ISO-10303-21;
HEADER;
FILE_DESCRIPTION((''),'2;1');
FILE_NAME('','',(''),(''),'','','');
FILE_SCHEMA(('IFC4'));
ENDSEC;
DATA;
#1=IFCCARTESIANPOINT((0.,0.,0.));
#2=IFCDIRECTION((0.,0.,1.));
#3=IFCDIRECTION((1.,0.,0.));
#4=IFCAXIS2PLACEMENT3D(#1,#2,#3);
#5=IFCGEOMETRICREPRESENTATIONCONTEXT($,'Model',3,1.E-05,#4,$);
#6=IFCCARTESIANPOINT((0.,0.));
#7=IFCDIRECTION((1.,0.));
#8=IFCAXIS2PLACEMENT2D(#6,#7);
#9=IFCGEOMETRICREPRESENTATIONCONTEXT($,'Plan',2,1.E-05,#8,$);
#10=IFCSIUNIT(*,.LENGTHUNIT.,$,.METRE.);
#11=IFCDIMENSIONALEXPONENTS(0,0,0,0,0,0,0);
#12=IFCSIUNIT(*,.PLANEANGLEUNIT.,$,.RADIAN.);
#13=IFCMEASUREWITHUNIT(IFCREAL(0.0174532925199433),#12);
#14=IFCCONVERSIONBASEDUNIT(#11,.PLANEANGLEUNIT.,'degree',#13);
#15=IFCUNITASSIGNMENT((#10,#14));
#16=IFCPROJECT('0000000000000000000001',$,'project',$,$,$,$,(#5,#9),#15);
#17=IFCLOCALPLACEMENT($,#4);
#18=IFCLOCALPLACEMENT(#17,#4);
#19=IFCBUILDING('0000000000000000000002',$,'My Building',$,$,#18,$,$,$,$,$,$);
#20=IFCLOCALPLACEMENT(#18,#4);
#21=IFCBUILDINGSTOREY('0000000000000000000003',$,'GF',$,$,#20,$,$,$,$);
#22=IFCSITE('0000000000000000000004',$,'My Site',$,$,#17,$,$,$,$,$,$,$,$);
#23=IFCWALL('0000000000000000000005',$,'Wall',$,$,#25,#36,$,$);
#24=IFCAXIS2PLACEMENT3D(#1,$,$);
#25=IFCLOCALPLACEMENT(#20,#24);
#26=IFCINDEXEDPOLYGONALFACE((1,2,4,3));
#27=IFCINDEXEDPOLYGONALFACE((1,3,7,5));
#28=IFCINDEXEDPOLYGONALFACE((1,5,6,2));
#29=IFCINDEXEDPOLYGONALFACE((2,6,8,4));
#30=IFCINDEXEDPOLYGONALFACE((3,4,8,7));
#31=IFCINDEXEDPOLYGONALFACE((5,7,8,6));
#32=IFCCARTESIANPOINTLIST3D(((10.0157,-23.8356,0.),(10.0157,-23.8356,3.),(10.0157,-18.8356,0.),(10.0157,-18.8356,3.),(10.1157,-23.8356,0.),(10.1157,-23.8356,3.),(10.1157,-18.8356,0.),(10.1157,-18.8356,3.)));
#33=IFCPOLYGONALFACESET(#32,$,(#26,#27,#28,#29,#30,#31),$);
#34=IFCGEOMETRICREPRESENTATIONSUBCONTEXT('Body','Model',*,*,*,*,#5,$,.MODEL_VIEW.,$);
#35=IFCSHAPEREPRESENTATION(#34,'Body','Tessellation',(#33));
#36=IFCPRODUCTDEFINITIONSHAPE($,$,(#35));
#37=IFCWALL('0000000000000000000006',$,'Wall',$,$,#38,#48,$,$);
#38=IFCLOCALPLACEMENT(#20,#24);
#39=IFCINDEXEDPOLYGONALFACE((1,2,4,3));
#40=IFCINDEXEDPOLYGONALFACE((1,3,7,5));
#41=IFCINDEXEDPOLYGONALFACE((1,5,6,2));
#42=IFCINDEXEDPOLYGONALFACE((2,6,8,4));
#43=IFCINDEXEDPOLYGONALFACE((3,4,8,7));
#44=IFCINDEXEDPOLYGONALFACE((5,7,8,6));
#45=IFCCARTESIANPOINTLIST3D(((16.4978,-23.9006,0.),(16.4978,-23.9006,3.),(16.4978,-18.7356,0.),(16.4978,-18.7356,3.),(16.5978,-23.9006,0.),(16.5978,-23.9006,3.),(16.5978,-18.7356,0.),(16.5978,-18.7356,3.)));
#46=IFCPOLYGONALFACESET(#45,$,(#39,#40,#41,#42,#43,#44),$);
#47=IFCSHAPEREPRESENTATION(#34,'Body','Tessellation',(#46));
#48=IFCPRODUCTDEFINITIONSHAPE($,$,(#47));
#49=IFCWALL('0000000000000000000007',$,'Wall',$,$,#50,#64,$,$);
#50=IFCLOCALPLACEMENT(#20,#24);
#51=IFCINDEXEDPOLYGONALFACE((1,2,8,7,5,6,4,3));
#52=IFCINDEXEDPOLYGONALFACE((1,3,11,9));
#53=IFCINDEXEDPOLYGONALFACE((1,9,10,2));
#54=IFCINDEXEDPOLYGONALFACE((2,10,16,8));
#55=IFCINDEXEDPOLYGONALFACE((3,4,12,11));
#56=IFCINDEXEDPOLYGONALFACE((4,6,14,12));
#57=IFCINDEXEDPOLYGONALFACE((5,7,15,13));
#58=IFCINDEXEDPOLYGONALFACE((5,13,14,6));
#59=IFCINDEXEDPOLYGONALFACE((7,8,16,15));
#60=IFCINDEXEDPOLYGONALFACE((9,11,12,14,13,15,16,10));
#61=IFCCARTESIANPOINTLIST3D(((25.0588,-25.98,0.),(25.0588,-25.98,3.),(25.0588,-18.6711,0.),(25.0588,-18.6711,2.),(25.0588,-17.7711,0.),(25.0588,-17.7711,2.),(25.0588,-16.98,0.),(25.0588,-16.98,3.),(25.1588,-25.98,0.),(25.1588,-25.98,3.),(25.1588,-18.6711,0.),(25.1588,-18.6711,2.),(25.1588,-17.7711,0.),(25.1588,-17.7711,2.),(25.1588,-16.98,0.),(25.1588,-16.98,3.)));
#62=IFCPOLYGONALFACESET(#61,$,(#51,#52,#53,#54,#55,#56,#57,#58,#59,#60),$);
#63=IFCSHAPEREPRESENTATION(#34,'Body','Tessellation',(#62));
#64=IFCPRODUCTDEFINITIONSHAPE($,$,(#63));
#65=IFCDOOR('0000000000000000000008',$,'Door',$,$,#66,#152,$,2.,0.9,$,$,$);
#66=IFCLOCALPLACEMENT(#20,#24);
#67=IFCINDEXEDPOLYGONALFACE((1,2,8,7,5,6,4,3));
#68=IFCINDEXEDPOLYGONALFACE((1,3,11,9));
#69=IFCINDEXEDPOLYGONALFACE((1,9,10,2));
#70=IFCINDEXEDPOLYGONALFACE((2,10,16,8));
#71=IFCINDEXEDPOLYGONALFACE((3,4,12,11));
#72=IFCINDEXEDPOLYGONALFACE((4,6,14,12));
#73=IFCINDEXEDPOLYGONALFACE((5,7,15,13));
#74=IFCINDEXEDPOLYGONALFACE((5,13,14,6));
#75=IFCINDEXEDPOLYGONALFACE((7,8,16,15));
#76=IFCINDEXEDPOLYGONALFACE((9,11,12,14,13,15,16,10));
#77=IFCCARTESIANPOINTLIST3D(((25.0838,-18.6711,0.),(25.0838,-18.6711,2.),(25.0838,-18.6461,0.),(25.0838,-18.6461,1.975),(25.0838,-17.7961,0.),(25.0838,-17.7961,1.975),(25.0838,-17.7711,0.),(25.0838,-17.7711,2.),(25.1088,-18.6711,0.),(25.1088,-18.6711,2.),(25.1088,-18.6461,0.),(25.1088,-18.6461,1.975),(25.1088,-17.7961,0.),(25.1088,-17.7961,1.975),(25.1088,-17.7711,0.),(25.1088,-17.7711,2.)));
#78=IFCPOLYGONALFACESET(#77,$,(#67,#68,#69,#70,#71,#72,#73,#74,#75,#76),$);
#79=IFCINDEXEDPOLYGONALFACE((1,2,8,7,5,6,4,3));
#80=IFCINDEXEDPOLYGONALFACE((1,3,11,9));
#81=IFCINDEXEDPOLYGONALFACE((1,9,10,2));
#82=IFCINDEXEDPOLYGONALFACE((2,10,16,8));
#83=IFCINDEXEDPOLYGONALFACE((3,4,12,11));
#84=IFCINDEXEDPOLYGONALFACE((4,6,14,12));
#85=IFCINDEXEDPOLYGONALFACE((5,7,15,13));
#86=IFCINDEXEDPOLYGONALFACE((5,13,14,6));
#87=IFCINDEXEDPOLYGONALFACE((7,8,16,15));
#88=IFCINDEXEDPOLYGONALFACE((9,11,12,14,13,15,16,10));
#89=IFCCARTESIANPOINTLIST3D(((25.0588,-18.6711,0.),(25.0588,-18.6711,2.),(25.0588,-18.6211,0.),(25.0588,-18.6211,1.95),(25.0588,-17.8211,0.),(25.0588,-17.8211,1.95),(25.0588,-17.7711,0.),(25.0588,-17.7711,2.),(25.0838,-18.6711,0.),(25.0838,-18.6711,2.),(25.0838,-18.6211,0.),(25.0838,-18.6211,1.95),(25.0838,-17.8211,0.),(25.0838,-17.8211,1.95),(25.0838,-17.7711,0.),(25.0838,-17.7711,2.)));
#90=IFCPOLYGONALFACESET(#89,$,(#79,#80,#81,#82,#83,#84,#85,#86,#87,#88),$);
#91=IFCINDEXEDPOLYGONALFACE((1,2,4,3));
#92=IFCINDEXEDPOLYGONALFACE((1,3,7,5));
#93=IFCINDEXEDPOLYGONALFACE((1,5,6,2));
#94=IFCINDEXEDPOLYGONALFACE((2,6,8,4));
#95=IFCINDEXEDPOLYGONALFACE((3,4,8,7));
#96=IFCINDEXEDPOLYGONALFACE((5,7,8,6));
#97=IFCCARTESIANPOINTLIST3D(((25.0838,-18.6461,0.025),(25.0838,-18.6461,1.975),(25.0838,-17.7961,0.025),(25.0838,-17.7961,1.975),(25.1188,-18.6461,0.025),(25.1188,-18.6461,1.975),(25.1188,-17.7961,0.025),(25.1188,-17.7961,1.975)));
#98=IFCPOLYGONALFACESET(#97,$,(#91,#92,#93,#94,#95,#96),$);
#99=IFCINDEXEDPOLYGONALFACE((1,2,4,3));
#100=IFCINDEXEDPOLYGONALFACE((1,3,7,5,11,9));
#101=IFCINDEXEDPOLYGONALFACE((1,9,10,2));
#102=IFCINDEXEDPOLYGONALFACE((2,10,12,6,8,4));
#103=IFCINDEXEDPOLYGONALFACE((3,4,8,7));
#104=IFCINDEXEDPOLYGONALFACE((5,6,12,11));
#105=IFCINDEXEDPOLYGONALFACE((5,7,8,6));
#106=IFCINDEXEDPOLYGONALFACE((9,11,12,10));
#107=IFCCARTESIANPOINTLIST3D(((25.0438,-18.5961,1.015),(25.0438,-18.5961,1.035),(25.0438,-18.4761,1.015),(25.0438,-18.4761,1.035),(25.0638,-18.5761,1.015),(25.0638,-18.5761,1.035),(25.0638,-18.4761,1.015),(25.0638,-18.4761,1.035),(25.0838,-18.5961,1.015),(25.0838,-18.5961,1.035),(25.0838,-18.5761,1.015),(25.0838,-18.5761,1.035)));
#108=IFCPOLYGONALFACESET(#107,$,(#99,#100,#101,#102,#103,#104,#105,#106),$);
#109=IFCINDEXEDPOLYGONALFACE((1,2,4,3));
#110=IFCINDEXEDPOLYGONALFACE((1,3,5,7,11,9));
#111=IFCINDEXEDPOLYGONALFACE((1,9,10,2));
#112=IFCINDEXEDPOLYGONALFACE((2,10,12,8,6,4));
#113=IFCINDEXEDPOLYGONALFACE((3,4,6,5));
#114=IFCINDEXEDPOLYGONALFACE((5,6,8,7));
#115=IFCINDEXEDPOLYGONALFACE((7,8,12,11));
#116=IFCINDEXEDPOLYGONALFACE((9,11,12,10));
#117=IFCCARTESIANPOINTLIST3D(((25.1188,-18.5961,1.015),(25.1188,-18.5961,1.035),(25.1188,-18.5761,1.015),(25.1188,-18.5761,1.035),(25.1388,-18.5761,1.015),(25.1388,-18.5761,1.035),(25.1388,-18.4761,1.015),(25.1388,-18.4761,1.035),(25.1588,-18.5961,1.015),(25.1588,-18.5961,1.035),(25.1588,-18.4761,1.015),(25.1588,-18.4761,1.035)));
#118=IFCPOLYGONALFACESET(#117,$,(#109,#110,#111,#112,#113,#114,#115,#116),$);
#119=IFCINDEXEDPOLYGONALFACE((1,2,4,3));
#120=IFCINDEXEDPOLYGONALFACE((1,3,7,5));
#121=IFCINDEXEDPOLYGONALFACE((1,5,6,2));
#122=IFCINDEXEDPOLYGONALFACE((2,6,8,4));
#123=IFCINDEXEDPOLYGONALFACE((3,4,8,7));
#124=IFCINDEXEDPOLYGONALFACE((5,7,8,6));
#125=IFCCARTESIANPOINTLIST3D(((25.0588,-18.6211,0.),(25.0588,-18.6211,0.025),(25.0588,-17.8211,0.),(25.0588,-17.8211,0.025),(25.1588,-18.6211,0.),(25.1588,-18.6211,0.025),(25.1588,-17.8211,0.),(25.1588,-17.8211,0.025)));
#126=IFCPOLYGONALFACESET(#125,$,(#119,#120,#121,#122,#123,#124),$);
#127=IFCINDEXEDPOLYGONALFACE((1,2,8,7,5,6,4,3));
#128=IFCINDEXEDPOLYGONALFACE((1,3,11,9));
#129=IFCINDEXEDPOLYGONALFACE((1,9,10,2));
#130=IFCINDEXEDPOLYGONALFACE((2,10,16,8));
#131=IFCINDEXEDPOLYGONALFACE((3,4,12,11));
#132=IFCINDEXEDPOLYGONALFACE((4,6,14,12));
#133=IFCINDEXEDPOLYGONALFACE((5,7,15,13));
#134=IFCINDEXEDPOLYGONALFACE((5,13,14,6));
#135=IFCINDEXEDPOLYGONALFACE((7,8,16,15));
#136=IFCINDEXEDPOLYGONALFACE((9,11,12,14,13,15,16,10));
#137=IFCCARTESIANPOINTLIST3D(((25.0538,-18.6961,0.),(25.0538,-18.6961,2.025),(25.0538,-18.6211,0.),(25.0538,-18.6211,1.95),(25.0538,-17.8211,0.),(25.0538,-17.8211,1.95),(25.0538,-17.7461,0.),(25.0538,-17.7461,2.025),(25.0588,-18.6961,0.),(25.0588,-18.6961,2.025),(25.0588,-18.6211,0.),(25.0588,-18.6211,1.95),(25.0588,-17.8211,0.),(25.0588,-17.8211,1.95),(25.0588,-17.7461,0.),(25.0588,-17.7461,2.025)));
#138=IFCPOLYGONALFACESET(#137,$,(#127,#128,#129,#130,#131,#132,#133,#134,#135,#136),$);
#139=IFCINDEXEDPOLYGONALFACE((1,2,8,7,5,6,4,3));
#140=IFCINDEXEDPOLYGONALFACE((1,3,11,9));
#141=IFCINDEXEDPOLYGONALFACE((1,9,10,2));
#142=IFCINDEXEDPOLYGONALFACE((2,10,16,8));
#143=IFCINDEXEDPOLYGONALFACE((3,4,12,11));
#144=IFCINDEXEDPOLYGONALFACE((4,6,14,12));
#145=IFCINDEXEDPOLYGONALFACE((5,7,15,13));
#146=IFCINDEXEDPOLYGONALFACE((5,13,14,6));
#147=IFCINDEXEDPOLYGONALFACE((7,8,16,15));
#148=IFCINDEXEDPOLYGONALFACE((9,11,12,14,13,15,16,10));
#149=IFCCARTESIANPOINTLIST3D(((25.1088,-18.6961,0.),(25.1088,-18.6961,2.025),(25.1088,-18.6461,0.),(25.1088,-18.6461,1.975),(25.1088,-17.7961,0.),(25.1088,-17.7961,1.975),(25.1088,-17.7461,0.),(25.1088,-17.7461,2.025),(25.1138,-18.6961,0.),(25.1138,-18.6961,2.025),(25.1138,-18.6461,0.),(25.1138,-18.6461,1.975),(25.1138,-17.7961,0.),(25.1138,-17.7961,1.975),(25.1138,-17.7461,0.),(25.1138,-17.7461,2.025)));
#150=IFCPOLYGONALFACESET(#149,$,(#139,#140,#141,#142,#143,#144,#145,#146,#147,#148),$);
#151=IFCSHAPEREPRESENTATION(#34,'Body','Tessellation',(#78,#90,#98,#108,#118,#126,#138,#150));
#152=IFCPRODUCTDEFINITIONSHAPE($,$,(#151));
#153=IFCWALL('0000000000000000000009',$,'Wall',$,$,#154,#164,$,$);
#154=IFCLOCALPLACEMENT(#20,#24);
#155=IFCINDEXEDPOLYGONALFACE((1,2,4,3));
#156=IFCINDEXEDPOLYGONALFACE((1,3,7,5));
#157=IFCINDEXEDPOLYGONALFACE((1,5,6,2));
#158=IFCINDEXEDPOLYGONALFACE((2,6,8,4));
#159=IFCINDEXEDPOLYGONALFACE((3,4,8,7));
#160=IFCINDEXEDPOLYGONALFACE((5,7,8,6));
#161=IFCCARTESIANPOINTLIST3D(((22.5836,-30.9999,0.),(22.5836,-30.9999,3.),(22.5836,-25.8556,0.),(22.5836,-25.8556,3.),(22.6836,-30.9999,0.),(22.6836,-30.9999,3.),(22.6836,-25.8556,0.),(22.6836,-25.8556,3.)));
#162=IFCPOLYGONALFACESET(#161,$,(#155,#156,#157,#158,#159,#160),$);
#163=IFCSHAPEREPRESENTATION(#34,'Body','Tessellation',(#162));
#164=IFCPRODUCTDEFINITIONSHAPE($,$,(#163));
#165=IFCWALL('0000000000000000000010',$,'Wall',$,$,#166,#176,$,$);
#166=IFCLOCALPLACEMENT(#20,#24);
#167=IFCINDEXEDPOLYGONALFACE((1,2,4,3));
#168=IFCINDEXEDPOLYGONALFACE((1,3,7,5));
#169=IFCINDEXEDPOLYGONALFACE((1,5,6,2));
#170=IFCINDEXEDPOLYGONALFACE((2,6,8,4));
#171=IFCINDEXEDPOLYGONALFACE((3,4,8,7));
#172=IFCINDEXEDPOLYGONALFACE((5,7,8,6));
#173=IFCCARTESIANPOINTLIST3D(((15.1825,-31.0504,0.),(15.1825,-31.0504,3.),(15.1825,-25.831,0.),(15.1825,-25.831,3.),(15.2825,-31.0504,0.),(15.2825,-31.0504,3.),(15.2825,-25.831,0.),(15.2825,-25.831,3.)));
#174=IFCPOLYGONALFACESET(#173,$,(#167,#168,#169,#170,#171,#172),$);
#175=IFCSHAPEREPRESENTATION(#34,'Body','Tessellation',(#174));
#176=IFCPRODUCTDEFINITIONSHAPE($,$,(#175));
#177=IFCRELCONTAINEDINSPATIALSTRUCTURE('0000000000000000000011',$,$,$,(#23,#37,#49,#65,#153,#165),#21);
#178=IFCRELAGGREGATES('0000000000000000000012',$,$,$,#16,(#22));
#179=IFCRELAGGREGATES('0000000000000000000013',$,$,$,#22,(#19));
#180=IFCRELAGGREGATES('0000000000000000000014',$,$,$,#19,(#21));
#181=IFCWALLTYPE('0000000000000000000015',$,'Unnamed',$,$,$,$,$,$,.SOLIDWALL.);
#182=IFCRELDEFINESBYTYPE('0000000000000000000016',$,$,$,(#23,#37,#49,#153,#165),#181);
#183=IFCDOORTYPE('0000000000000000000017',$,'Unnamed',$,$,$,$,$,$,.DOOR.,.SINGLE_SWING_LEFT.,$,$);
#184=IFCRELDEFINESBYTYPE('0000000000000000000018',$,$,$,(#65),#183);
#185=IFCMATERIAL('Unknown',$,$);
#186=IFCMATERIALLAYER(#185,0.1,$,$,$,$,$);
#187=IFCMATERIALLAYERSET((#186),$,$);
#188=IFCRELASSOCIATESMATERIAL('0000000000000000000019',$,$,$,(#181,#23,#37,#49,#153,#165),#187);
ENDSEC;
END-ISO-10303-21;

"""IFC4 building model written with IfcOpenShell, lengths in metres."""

from ifc_helpers import new_model, entity, si_unit, converted_unit, frame, origin_with_axes, origin_2d_with_axis, place, context, subcontext, project, spatial, line, indexed_curve, outline, extrude, shape, source, transform, mapped, material, layer, layer_set, layer_usage, type_object, type_shapes, element, fill, save


model = new_model("IFC4")

# Units and contexts
model_context = context("Model", 3, precision=1e-05, world=origin_with_axes())
plan_context = context("Plan", 2, precision=1e-05, world=origin_2d_with_axis())
body_context_1 = subcontext(model_context, "Body", "Model", "MODEL_VIEW")
body_context_2 = subcontext(plan_context, "Body", "Plan", "PLAN_VIEW")
ifc_project = project(units=[si_unit("LENGTHUNIT", "METRE"), converted_unit("PLANEANGLEUNIT", "degree", entity("IfcReal", 0.0174532925199433), si_unit("PLANEANGLEUNIT", "RADIAN"), dimensions=[0, 0, 0, 0, 0, 0, 0])], contexts=[model_context, plan_context])

# Site, building, storey
site_placement = place(None, origin_with_axes())
site = spatial("IfcSite", under=ifc_project, at=site_placement, Name="My Site")
building_placement = place(site_placement, origin_with_axes())
building = spatial("IfcBuilding", under=site, at=building_placement, Name="My Building")
storey_placement = place(building_placement, origin_with_axes())
storey = spatial("IfcBuildingStorey", under=building, at=storey_placement, Name="GF")

# Shared definitions
ifc_material = material(Name="Unknown")
ifc_layer = layer(ifc_material, 0.1)
ifc_layer_set = layer_set([ifc_layer])
wall_type = type_object("IfcWallType", Name="Unnamed", PredefinedType="SOLIDWALL", material=ifc_layer_set)

# Shared definitions
shared_shape_1 = source(origin_with_axes(), body_context_1, "Body", "SweptSolid", [
    extrude(outline(indexed_curve([(0.0, 0.0), (0.9, 0.0), (0.9, 2.0), (0.0, 2.0)], segments=[line(1, 2, 3, 4, 1)])), frame((0.0, -0.6, 0.0), z_axis=(0.0, -1.0, 0.0), x_axis=(1.0, 0.0, 0.0)), (0.0, 0.0, -1.0), 1.2),
])
door_type = type_object("IfcDoorType", Name="Unnamed", OperationType="SINGLE_SWING_LEFT", PredefinedType="DOOR")
shared_shape_2 = source(origin_with_axes(), body_context_1, "Body", "SweptSolid", [
    extrude(outline(indexed_curve([(0.0, 0.0), (0.0, 2.0), (0.9, 2.0), (0.9, 0.0), (0.875, 0.0), (0.875, 1.975), (0.025, 1.975), (0.025, 0.0)], segments=[line(1, 2, 3, 4, 5, 6, 7, 8, 1)])), frame((0.0, 0.025, 0.0), z_axis=(0.0, -1.0, 0.0), x_axis=(1.0, 0.0, 0.0)), (0.0, 0.0, -1.0), 0.025),
    extrude(outline(indexed_curve([(0.0, 0.0), (0.0, 2.0), (0.9, 2.0), (0.9, 0.0), (0.85, 0.0), (0.85, 1.95), (0.05, 1.95), (0.05, 0.0)], segments=[line(1, 2, 3, 4, 5, 6, 7, 8, 1)])), frame((0.0, 0.0, 0.0), z_axis=(0.0, -1.0, 0.0), x_axis=(1.0, 0.0, 0.0)), (0.0, 0.0, -1.0), 0.025),
    extrude(outline(indexed_curve([(0.0, 0.0), (0.85, 0.0), (0.85, 0.035), (0.0, 0.035)], segments=[line(1, 2, 3, 4, 1)])), frame((0.025, 0.025, 0.025), z_axis=(0.0, 0.0, 1.0), x_axis=(1.0, 0.0, 0.0)), (0.0, 0.0, 1.0), 1.95),
    extrude(outline(indexed_curve([(0.0, 0.0), (0.0, -0.04), (-0.12, -0.04), (-0.12, -0.02), (-0.02, -0.02), (-0.02, 0.0)], segments=[line(1, 2, 3, 4, 5, 6, 1)])), frame((0.825, 0.025, 1.015), z_axis=(0.0, 0.0, 1.0), x_axis=(1.0, 0.0, 0.0)), (0.0, 0.0, 1.0), 0.02),
    extrude(outline(indexed_curve([(0.0, 0.0), (0.0, 0.04), (-0.12, 0.04), (-0.12, 0.02), (-0.02, 0.02), (-0.02, 0.0)], segments=[line(1, 2, 3, 4, 5, 6, 1)])), frame((0.825, 0.06, 1.015), z_axis=(0.0, 0.0, 1.0), x_axis=(1.0, 0.0, 0.0)), (0.0, 0.0, 1.0), 0.02),
    extrude(outline(indexed_curve([(0.0, 0.0), (0.8, 0.0), (0.8, 0.1), (0.0, 0.1)], segments=[line(1, 2, 3, 4, 1)])), frame((0.05, 0.0, 0.0), z_axis=(0.0, 0.0, 1.0), x_axis=(1.0, 0.0, 0.0)), (0.0, 0.0, 1.0), 0.025),
    extrude(outline(indexed_curve([(0.0, 0.0), (0.0, 2.025), (0.95, 2.025), (0.95, 0.0), (0.875, 0.0), (0.875, 1.95), (0.075, 1.95), (0.075, 0.0)], segments=[line(1, 2, 3, 4, 5, 6, 7, 8, 1)])), frame((-0.025, -0.005, 0.0), z_axis=(0.0, -1.0, 0.0), x_axis=(1.0, 0.0, 0.0)), (0.0, 0.0, -1.0), 0.005),
    extrude(outline(indexed_curve([(0.0, 0.0), (0.0, 2.025), (0.95, 2.025), (0.95, 0.0), (0.9, 0.0), (0.9, 1.975), (0.05, 1.975), (0.05, 0.0)], segments=[line(1, 2, 3, 4, 5, 6, 7, 8, 1)])), frame((-0.025, 0.05, 0.0), z_axis=(0.0, -1.0, 0.0), x_axis=(1.0, 0.0, 0.0)), (0.0, 0.0, -1.0), 0.005),
])
shared_shape_3 = source(origin_with_axes(), body_context_2, "Body", "Curve2D", [
    entity("IfcIndexedPolyCurve", entity("IfcCartesianPointList2D", [[0.0, 0.0], [0.0, 0.05], [0.025, 0.05], [0.025, 0.025], [0.05, 0.025], [0.05, 0.0]]), [entity("IfcLineIndex", [1, 2, 3, 4, 5, 6, 1])]),
    entity("IfcIndexedPolyCurve", entity("IfcCartesianPointList2D", [[0.9, 0.0], [0.9, 0.05], [0.875, 0.05], [0.875, 0.025], [0.85, 0.025], [0.85, 0.0]]), [entity("IfcLineIndex", [1, 2, 3, 4, 5, 6, 1])]),
    entity("IfcTrimmedCurve", entity("IfcEllipse", entity("IfcAxis2Placement2D", entity("IfcCartesianPoint", [0.06, 0.05]), entity("IfcDirection", [1.0, 0.0])), 0.815, 0.85), [entity("IfcCartesianPoint", [0.875, 0.05])], [entity("IfcCartesianPoint", [0.06, 0.9])], True, "CARTESIAN"),
    entity("IfcIndexedPolyCurve", entity("IfcCartesianPointList2D", [[0.025, 0.05], [0.06, 0.05], [0.06, 0.9], [0.025, 0.9]]), [entity("IfcLineIndex", [1, 2, 3, 4, 1])]),
])
type_shapes(door_type, [shared_shape_2, shared_shape_3])

# Walls
ifc_layer_usage_1 = layer_usage(ifc_layer_set, "AXIS2", "POSITIVE", 0.0)
wall_1_placement = place(storey_placement, frame((10.0157, -18.8356, 0.0), z_axis=(0.0, 0.0, 1.0), x_axis=(0.0, -1.0, 0.0)))
element("IfcWall", 1, at=wall_1_placement, inside=storey, type_object=wall_type, material=ifc_layer_usage_1, Name="Wall", context=body_context_1, shape_type="SweptSolid", body=[
    extrude(outline(indexed_curve([(0.0, 0.0), (0.0, 0.1), (5.0, 0.1), (5.0, 0.0)], segments=[line(1, 2, 3, 4, 1)])), origin_with_axes(), (0.0, 0.0, 1.0), 3.0),
])
ifc_layer_usage_2 = layer_usage(ifc_layer_set, "AXIS2", "POSITIVE", 0.0)
wall_2_placement = place(storey_placement, frame((16.4978, -18.7356, 0.0), z_axis=(0.0, 0.0, 1.0), x_axis=(0.0, -1.0, 0.0)))
element("IfcWall", 2, at=wall_2_placement, inside=storey, type_object=wall_type, material=ifc_layer_usage_2, Name="Wall", context=body_context_1, shape_type="SweptSolid", body=[
    extrude(outline(indexed_curve([(0.0, 0.0), (0.0, 0.1), (5.1651, 0.1), (5.1651, 0.0)], segments=[line(1, 2, 3, 4, 1)])), origin_with_axes(), (0.0, 0.0, 1.0), 3.0),
])

# Wall, opening, door
ifc_layer_usage_3 = layer_usage(ifc_layer_set, "AXIS2", "POSITIVE", 0.0)
wall_3_placement = place(storey_placement, frame((25.0588, -16.98, 0.0), z_axis=(0.0, 0.0, 1.0), x_axis=(0.0, -1.0, 0.0)))
wall_3 = element("IfcWall", 3, at=wall_3_placement, inside=storey, type_object=wall_type, material=ifc_layer_usage_3, Name="Wall", context=body_context_1, shape_type="SweptSolid", body=[
    extrude(outline(indexed_curve([(0.0, 0.0), (0.0, 0.1), (9.0, 0.1), (9.0, 0.0)], segments=[line(1, 2, 3, 4, 1)])), origin_with_axes(), (0.0, 0.0, 1.0), 3.0),
])
opening_1_placement = place(wall_3_placement, frame((0.7911, 0.0, 0.0), z_axis=(0.0, 0.0, 1.0), x_axis=(1.0, 0.0, 0.0)))
opening_1 = element("IfcOpeningElement", 4, at=opening_1_placement, cuts=wall_3, PredefinedType="OPENING", context=body_context_1, shape_type="MappedRepresentation", body=[
    mapped(shared_shape_1, transform((0.0, 0.0, 0.0), x_axis=(1.0, 0.0, 0.0), y_axis=(0.0, 1.0, 0.0), z_axis=(0.0, 0.0, 1.0), scale=1.0)),
])
door_1_placement = place(opening_1_placement, frame((0.0, 0.0, 0.0), z_axis=(0.0, 0.0, 1.0), x_axis=(1.0, 0.0, 0.0)))
door_1 = element("IfcDoor", 5, at=door_1_placement, inside=storey, type_object=door_type, Name="Door", OverallHeight=2.0, OverallWidth=0.9, shapes=[
    shape(body_context_1, "Body", "MappedRepresentation", [mapped(shared_shape_2, transform((0.0, 0.0, 0.0), x_axis=(1.0, 0.0, 0.0), y_axis=(0.0, 1.0, 0.0), z_axis=(0.0, 0.0, 1.0), scale=1.0))]),
    shape(body_context_2, "Body", "MappedRepresentation", [mapped(shared_shape_3, transform((0.0, 0.0, 0.0), x_axis=(1.0, 0.0, 0.0), y_axis=(0.0, 1.0, 0.0), z_axis=(0.0, 0.0, 1.0), scale=1.0))]),
])
fill(opening_1, door_1)

# Walls
ifc_layer_usage_4 = layer_usage(ifc_layer_set, "AXIS2", "POSITIVE", 0.0)
wall_4_placement = place(storey_placement, frame((22.5836, -25.8556, 0.0), z_axis=(0.0, 0.0, 1.0), x_axis=(0.0, -1.0, 0.0)))
element("IfcWall", 6, at=wall_4_placement, inside=storey, type_object=wall_type, material=ifc_layer_usage_4, Name="Wall", context=body_context_1, shape_type="SweptSolid", body=[
    extrude(outline(indexed_curve([(0.0, 0.0), (0.0, 0.1), (5.1443, 0.1), (5.1443, 0.0)], segments=[line(1, 2, 3, 4, 1)])), origin_with_axes(), (0.0, 0.0, 1.0), 3.0),
])
ifc_layer_usage_5 = layer_usage(ifc_layer_set, "AXIS2", "POSITIVE", 0.0)
wall_5_placement = place(storey_placement, frame((15.1825, -25.831, 0.0), z_axis=(0.0, 0.0, 1.0), x_axis=(0.0, -1.0, 0.0)))
element("IfcWall", 7, at=wall_5_placement, inside=storey, type_object=wall_type, material=ifc_layer_usage_5, Name="Wall", context=body_context_1, shape_type="SweptSolid", body=[
    extrude(outline(indexed_curve([(0.0, 0.0), (0.0, 0.1), (5.2194, 0.1), (5.2194, 0.0)], segments=[line(1, 2, 3, 4, 1)])), origin_with_axes(), (0.0, 0.0, 1.0), 3.0),
])

save(model, "model.ifc")
